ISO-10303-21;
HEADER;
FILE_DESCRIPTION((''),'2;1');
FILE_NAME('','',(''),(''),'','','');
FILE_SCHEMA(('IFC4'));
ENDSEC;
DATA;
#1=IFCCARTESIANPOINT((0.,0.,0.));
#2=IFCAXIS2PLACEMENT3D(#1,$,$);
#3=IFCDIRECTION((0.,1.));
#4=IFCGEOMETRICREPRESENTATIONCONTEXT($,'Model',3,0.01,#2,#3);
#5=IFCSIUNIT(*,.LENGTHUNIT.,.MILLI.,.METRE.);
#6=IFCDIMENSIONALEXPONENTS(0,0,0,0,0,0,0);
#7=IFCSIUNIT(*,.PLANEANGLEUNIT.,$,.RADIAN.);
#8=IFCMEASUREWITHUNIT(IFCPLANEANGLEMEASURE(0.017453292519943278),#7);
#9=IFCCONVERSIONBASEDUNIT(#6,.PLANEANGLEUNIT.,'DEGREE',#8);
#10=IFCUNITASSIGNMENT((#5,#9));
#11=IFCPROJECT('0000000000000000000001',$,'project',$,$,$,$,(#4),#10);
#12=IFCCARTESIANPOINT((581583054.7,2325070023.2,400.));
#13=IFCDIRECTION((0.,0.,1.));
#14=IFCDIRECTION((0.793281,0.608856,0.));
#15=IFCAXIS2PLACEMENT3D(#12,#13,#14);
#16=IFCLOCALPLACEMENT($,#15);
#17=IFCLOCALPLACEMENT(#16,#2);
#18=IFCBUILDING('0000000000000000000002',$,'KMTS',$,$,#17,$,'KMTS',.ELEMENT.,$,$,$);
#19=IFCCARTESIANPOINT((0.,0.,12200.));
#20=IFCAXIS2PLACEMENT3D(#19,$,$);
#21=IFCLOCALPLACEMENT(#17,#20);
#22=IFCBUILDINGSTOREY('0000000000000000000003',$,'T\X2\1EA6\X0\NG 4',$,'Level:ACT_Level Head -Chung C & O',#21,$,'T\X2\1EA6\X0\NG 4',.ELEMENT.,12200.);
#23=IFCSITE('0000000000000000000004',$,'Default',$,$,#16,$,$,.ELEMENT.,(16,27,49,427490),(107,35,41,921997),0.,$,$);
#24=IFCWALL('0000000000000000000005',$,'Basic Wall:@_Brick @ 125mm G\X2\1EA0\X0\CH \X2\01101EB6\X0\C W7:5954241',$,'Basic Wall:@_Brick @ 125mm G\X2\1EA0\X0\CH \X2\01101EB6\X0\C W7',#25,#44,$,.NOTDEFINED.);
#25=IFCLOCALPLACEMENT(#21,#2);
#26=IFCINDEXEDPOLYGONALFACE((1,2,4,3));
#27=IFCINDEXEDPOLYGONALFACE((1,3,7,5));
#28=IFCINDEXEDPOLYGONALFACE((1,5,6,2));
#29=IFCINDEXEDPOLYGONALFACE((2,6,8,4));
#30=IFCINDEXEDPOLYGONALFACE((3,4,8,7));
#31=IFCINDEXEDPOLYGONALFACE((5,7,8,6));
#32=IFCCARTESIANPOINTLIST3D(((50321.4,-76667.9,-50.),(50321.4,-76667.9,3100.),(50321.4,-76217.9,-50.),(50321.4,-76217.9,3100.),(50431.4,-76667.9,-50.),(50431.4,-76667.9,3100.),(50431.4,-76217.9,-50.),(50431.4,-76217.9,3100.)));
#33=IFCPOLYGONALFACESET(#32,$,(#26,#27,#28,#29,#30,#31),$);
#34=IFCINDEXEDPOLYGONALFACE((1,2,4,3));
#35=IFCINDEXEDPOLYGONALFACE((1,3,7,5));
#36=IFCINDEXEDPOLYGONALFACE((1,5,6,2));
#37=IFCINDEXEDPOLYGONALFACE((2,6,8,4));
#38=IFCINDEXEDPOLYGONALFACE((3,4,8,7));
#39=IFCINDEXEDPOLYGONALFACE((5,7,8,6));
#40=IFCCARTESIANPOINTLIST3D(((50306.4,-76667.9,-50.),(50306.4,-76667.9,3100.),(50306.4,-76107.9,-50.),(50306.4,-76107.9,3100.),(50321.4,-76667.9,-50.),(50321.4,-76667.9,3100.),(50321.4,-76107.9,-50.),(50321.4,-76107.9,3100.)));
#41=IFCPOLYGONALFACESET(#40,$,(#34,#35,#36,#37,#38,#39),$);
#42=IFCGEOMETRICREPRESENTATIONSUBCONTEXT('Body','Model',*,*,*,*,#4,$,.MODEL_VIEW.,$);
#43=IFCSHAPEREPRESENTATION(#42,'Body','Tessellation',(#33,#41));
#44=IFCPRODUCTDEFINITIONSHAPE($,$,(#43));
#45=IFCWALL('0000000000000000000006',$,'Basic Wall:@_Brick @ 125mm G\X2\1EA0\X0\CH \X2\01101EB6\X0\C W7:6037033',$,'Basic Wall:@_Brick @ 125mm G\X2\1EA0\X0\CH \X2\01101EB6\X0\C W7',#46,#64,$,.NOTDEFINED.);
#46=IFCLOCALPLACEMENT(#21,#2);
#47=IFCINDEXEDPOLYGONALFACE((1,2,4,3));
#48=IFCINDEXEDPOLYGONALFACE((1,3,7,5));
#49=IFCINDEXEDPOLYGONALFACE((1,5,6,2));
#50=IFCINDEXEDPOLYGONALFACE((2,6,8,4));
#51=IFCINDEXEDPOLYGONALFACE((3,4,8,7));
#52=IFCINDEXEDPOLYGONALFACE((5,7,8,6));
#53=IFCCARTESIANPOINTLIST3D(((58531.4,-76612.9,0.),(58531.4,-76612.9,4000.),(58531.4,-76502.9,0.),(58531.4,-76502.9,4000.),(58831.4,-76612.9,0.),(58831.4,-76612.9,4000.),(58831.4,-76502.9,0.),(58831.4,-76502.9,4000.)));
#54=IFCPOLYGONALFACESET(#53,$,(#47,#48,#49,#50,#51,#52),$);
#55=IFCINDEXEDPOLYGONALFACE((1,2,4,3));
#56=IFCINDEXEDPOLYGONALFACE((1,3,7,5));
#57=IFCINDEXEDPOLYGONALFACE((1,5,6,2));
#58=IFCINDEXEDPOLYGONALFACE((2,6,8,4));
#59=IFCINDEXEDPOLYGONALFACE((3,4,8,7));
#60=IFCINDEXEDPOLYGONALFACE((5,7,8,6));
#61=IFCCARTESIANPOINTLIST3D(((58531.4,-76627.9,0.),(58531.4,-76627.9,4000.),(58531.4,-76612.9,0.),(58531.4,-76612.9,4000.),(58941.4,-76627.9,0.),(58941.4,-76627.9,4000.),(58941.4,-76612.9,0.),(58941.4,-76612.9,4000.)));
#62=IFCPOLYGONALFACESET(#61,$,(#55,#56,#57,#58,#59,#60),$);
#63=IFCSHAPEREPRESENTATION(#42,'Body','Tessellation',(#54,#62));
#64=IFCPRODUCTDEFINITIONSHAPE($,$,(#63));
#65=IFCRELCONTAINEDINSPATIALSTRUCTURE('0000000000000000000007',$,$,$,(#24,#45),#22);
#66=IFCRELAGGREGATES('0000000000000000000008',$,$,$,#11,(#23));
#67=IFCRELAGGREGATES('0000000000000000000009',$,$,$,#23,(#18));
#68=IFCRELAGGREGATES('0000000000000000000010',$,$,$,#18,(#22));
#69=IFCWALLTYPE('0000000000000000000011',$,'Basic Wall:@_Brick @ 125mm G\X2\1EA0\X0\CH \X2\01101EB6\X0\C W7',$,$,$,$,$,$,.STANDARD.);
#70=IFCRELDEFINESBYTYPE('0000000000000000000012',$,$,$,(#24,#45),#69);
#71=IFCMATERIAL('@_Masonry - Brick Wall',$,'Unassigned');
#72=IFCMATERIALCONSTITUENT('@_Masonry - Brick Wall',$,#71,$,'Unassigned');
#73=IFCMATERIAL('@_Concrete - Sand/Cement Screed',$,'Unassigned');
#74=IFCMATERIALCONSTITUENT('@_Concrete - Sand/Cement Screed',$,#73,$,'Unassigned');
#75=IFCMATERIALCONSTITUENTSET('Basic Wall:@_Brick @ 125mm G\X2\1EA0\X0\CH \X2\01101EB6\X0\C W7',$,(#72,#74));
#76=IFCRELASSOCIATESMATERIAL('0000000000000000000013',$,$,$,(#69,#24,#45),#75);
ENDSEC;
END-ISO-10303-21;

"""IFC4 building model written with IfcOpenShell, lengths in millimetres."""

from ifc_helpers import new_model, entity, si_unit, converted_unit, direction, frame, origin, place, context, subcontext, project, spatial, indexed_curve, outline, extrude, material, constituent, constituent_set, type_object, element, save


model = new_model("IFC4")

# Units and contexts
model_context = context("Model", 3, precision=0.01, world=origin(), true_north=direction((0.0, 1.0)))
body_context = subcontext(model_context, "Body", "Model", "MODEL_VIEW")
ifc_project = project(units=[si_unit("LENGTHUNIT", "METRE", prefix="MILLI"), converted_unit("PLANEANGLEUNIT", "DEGREE", entity("IfcPlaneAngleMeasure", 0.017453292519943278), si_unit("PLANEANGLEUNIT", "RADIAN"), dimensions=[0, 0, 0, 0, 0, 0, 0])], contexts=[model_context])

# Site, building, storey
site_placement = place(None, frame((581583054.7, 2325070023.2, 400.0), z_axis=(0.0, 0.0, 1.0), x_axis=(0.793281, 0.608856, 0.0)))
site = spatial("IfcSite", under=ifc_project, at=site_placement, Name="Default", CompositionType="ELEMENT", RefLatitude=(16, 27, 49, 427490), RefLongitude=(107, 35, 41, 921997), RefElevation=0.0)
building_placement = place(site_placement, origin())
building = spatial("IfcBuilding", under=site, at=building_placement, Name="KMTS", LongName="KMTS", CompositionType="ELEMENT")
storey_placement = place(building_placement, frame((0.0, 0.0, 12200.0)))
storey = spatial("IfcBuildingStorey", under=building, at=storey_placement, Name="TẦNG 4", ObjectType="Level:ACT_Level Head -Chung C & O", LongName="TẦNG 4", CompositionType="ELEMENT", Elevation=12200.0)

# Walls
ifc_material_1 = material(Name="@_Masonry - Brick Wall", Category="Unassigned")
ifc_constituent_1 = constituent(ifc_material_1, Name="@_Masonry - Brick Wall", Category="Unassigned")
ifc_material_2 = material(Name="@_Concrete - Sand/Cement Screed", Category="Unassigned")
ifc_constituent_2 = constituent(ifc_material_2, Name="@_Concrete - Sand/Cement Screed", Category="Unassigned")
ifc_constituent_set_1 = constituent_set(constituents=[ifc_constituent_1, ifc_constituent_2], Name="Basic Wall:@_Brick @ 125mm GẠCH ĐẶC W7")
wall_type_1 = type_object("IfcWallType", Name="Basic Wall:@_Brick @ 125mm GẠCH ĐẶC W7", PredefinedType="STANDARD", material=ifc_constituent_set_1)
wall_1_placement = place(storey_placement, frame((50368.9, -76217.9, -50.0), z_axis=(0.0, 0.0, 1.0), x_axis=(0.0, -1.0, 0.0)))
element("IfcWall", 1, at=wall_1_placement, inside=storey, type_object=wall_type_1, material=ifc_constituent_set_1, Name="Basic Wall:@_Brick @ 125mm GẠCH ĐẶC W7:5954241", ObjectType="Basic Wall:@_Brick @ 125mm GẠCH ĐẶC W7", PredefinedType="NOTDEFINED", context=body_context, shape_type="SweptSolid", body=[
    extrude(outline(indexed_curve([(-55.0, -225.0), (55.0, -225.0), (55.0, 225.0), (-55.0, 225.0), (-55.0, -225.0)], self_intersect=False)), frame((225.0, 7.5, 0.0), z_axis=(0.0, 0.0, 1.0), x_axis=(0.0, -1.0, 0.0)), (0.0, 0.0, 1.0), 3150.0),
    extrude(outline(indexed_curve([(-7.5, -280.0), (7.5, -280.0), (7.5, 280.0), (-7.5, 280.0), (-7.5, -280.0)], self_intersect=False)), frame((170.0, -55.0, 0.0), z_axis=(0.0, 0.0, 1.0), x_axis=(0.0, 1.0, 0.0)), (0.0, 0.0, 1.0), 3150.0),
])
wall_2_placement = place(storey_placement, frame((58831.4, -76565.4, 0.0), z_axis=(0.0, 0.0, 1.0), x_axis=(-1.0, 0.0, 0.0)))
element("IfcWall", 2, at=wall_2_placement, inside=storey, type_object=wall_type_1, material=ifc_constituent_set_1, Name="Basic Wall:@_Brick @ 125mm GẠCH ĐẶC W7:6037033", ObjectType="Basic Wall:@_Brick @ 125mm GẠCH ĐẶC W7", PredefinedType="NOTDEFINED", context=body_context, shape_type="SweptSolid", body=[
    extrude(outline(indexed_curve([(-55.0, -150.0), (55.0, -150.0), (55.0, 150.0), (-55.0, 150.0), (-55.0, -150.0)], self_intersect=False)), frame((150.0, -7.5, 0.0), z_axis=(0.0, 0.0, 1.0), x_axis=(0.0, 1.0, 0.0)), (0.0, 0.0, 1.0), 4000.0),
    extrude(outline(indexed_curve([(-7.5, -205.0), (7.5, -205.0), (7.5, 205.0), (-7.5, 205.0), (-7.5, -205.0)], self_intersect=False)), frame((95.0, 55.0, 0.0), z_axis=(0.0, 0.0, 1.0), x_axis=(0.0, -1.0, 0.0)), (0.0, 0.0, 1.0), 4000.0),
])

save(model, "model.ifc")
